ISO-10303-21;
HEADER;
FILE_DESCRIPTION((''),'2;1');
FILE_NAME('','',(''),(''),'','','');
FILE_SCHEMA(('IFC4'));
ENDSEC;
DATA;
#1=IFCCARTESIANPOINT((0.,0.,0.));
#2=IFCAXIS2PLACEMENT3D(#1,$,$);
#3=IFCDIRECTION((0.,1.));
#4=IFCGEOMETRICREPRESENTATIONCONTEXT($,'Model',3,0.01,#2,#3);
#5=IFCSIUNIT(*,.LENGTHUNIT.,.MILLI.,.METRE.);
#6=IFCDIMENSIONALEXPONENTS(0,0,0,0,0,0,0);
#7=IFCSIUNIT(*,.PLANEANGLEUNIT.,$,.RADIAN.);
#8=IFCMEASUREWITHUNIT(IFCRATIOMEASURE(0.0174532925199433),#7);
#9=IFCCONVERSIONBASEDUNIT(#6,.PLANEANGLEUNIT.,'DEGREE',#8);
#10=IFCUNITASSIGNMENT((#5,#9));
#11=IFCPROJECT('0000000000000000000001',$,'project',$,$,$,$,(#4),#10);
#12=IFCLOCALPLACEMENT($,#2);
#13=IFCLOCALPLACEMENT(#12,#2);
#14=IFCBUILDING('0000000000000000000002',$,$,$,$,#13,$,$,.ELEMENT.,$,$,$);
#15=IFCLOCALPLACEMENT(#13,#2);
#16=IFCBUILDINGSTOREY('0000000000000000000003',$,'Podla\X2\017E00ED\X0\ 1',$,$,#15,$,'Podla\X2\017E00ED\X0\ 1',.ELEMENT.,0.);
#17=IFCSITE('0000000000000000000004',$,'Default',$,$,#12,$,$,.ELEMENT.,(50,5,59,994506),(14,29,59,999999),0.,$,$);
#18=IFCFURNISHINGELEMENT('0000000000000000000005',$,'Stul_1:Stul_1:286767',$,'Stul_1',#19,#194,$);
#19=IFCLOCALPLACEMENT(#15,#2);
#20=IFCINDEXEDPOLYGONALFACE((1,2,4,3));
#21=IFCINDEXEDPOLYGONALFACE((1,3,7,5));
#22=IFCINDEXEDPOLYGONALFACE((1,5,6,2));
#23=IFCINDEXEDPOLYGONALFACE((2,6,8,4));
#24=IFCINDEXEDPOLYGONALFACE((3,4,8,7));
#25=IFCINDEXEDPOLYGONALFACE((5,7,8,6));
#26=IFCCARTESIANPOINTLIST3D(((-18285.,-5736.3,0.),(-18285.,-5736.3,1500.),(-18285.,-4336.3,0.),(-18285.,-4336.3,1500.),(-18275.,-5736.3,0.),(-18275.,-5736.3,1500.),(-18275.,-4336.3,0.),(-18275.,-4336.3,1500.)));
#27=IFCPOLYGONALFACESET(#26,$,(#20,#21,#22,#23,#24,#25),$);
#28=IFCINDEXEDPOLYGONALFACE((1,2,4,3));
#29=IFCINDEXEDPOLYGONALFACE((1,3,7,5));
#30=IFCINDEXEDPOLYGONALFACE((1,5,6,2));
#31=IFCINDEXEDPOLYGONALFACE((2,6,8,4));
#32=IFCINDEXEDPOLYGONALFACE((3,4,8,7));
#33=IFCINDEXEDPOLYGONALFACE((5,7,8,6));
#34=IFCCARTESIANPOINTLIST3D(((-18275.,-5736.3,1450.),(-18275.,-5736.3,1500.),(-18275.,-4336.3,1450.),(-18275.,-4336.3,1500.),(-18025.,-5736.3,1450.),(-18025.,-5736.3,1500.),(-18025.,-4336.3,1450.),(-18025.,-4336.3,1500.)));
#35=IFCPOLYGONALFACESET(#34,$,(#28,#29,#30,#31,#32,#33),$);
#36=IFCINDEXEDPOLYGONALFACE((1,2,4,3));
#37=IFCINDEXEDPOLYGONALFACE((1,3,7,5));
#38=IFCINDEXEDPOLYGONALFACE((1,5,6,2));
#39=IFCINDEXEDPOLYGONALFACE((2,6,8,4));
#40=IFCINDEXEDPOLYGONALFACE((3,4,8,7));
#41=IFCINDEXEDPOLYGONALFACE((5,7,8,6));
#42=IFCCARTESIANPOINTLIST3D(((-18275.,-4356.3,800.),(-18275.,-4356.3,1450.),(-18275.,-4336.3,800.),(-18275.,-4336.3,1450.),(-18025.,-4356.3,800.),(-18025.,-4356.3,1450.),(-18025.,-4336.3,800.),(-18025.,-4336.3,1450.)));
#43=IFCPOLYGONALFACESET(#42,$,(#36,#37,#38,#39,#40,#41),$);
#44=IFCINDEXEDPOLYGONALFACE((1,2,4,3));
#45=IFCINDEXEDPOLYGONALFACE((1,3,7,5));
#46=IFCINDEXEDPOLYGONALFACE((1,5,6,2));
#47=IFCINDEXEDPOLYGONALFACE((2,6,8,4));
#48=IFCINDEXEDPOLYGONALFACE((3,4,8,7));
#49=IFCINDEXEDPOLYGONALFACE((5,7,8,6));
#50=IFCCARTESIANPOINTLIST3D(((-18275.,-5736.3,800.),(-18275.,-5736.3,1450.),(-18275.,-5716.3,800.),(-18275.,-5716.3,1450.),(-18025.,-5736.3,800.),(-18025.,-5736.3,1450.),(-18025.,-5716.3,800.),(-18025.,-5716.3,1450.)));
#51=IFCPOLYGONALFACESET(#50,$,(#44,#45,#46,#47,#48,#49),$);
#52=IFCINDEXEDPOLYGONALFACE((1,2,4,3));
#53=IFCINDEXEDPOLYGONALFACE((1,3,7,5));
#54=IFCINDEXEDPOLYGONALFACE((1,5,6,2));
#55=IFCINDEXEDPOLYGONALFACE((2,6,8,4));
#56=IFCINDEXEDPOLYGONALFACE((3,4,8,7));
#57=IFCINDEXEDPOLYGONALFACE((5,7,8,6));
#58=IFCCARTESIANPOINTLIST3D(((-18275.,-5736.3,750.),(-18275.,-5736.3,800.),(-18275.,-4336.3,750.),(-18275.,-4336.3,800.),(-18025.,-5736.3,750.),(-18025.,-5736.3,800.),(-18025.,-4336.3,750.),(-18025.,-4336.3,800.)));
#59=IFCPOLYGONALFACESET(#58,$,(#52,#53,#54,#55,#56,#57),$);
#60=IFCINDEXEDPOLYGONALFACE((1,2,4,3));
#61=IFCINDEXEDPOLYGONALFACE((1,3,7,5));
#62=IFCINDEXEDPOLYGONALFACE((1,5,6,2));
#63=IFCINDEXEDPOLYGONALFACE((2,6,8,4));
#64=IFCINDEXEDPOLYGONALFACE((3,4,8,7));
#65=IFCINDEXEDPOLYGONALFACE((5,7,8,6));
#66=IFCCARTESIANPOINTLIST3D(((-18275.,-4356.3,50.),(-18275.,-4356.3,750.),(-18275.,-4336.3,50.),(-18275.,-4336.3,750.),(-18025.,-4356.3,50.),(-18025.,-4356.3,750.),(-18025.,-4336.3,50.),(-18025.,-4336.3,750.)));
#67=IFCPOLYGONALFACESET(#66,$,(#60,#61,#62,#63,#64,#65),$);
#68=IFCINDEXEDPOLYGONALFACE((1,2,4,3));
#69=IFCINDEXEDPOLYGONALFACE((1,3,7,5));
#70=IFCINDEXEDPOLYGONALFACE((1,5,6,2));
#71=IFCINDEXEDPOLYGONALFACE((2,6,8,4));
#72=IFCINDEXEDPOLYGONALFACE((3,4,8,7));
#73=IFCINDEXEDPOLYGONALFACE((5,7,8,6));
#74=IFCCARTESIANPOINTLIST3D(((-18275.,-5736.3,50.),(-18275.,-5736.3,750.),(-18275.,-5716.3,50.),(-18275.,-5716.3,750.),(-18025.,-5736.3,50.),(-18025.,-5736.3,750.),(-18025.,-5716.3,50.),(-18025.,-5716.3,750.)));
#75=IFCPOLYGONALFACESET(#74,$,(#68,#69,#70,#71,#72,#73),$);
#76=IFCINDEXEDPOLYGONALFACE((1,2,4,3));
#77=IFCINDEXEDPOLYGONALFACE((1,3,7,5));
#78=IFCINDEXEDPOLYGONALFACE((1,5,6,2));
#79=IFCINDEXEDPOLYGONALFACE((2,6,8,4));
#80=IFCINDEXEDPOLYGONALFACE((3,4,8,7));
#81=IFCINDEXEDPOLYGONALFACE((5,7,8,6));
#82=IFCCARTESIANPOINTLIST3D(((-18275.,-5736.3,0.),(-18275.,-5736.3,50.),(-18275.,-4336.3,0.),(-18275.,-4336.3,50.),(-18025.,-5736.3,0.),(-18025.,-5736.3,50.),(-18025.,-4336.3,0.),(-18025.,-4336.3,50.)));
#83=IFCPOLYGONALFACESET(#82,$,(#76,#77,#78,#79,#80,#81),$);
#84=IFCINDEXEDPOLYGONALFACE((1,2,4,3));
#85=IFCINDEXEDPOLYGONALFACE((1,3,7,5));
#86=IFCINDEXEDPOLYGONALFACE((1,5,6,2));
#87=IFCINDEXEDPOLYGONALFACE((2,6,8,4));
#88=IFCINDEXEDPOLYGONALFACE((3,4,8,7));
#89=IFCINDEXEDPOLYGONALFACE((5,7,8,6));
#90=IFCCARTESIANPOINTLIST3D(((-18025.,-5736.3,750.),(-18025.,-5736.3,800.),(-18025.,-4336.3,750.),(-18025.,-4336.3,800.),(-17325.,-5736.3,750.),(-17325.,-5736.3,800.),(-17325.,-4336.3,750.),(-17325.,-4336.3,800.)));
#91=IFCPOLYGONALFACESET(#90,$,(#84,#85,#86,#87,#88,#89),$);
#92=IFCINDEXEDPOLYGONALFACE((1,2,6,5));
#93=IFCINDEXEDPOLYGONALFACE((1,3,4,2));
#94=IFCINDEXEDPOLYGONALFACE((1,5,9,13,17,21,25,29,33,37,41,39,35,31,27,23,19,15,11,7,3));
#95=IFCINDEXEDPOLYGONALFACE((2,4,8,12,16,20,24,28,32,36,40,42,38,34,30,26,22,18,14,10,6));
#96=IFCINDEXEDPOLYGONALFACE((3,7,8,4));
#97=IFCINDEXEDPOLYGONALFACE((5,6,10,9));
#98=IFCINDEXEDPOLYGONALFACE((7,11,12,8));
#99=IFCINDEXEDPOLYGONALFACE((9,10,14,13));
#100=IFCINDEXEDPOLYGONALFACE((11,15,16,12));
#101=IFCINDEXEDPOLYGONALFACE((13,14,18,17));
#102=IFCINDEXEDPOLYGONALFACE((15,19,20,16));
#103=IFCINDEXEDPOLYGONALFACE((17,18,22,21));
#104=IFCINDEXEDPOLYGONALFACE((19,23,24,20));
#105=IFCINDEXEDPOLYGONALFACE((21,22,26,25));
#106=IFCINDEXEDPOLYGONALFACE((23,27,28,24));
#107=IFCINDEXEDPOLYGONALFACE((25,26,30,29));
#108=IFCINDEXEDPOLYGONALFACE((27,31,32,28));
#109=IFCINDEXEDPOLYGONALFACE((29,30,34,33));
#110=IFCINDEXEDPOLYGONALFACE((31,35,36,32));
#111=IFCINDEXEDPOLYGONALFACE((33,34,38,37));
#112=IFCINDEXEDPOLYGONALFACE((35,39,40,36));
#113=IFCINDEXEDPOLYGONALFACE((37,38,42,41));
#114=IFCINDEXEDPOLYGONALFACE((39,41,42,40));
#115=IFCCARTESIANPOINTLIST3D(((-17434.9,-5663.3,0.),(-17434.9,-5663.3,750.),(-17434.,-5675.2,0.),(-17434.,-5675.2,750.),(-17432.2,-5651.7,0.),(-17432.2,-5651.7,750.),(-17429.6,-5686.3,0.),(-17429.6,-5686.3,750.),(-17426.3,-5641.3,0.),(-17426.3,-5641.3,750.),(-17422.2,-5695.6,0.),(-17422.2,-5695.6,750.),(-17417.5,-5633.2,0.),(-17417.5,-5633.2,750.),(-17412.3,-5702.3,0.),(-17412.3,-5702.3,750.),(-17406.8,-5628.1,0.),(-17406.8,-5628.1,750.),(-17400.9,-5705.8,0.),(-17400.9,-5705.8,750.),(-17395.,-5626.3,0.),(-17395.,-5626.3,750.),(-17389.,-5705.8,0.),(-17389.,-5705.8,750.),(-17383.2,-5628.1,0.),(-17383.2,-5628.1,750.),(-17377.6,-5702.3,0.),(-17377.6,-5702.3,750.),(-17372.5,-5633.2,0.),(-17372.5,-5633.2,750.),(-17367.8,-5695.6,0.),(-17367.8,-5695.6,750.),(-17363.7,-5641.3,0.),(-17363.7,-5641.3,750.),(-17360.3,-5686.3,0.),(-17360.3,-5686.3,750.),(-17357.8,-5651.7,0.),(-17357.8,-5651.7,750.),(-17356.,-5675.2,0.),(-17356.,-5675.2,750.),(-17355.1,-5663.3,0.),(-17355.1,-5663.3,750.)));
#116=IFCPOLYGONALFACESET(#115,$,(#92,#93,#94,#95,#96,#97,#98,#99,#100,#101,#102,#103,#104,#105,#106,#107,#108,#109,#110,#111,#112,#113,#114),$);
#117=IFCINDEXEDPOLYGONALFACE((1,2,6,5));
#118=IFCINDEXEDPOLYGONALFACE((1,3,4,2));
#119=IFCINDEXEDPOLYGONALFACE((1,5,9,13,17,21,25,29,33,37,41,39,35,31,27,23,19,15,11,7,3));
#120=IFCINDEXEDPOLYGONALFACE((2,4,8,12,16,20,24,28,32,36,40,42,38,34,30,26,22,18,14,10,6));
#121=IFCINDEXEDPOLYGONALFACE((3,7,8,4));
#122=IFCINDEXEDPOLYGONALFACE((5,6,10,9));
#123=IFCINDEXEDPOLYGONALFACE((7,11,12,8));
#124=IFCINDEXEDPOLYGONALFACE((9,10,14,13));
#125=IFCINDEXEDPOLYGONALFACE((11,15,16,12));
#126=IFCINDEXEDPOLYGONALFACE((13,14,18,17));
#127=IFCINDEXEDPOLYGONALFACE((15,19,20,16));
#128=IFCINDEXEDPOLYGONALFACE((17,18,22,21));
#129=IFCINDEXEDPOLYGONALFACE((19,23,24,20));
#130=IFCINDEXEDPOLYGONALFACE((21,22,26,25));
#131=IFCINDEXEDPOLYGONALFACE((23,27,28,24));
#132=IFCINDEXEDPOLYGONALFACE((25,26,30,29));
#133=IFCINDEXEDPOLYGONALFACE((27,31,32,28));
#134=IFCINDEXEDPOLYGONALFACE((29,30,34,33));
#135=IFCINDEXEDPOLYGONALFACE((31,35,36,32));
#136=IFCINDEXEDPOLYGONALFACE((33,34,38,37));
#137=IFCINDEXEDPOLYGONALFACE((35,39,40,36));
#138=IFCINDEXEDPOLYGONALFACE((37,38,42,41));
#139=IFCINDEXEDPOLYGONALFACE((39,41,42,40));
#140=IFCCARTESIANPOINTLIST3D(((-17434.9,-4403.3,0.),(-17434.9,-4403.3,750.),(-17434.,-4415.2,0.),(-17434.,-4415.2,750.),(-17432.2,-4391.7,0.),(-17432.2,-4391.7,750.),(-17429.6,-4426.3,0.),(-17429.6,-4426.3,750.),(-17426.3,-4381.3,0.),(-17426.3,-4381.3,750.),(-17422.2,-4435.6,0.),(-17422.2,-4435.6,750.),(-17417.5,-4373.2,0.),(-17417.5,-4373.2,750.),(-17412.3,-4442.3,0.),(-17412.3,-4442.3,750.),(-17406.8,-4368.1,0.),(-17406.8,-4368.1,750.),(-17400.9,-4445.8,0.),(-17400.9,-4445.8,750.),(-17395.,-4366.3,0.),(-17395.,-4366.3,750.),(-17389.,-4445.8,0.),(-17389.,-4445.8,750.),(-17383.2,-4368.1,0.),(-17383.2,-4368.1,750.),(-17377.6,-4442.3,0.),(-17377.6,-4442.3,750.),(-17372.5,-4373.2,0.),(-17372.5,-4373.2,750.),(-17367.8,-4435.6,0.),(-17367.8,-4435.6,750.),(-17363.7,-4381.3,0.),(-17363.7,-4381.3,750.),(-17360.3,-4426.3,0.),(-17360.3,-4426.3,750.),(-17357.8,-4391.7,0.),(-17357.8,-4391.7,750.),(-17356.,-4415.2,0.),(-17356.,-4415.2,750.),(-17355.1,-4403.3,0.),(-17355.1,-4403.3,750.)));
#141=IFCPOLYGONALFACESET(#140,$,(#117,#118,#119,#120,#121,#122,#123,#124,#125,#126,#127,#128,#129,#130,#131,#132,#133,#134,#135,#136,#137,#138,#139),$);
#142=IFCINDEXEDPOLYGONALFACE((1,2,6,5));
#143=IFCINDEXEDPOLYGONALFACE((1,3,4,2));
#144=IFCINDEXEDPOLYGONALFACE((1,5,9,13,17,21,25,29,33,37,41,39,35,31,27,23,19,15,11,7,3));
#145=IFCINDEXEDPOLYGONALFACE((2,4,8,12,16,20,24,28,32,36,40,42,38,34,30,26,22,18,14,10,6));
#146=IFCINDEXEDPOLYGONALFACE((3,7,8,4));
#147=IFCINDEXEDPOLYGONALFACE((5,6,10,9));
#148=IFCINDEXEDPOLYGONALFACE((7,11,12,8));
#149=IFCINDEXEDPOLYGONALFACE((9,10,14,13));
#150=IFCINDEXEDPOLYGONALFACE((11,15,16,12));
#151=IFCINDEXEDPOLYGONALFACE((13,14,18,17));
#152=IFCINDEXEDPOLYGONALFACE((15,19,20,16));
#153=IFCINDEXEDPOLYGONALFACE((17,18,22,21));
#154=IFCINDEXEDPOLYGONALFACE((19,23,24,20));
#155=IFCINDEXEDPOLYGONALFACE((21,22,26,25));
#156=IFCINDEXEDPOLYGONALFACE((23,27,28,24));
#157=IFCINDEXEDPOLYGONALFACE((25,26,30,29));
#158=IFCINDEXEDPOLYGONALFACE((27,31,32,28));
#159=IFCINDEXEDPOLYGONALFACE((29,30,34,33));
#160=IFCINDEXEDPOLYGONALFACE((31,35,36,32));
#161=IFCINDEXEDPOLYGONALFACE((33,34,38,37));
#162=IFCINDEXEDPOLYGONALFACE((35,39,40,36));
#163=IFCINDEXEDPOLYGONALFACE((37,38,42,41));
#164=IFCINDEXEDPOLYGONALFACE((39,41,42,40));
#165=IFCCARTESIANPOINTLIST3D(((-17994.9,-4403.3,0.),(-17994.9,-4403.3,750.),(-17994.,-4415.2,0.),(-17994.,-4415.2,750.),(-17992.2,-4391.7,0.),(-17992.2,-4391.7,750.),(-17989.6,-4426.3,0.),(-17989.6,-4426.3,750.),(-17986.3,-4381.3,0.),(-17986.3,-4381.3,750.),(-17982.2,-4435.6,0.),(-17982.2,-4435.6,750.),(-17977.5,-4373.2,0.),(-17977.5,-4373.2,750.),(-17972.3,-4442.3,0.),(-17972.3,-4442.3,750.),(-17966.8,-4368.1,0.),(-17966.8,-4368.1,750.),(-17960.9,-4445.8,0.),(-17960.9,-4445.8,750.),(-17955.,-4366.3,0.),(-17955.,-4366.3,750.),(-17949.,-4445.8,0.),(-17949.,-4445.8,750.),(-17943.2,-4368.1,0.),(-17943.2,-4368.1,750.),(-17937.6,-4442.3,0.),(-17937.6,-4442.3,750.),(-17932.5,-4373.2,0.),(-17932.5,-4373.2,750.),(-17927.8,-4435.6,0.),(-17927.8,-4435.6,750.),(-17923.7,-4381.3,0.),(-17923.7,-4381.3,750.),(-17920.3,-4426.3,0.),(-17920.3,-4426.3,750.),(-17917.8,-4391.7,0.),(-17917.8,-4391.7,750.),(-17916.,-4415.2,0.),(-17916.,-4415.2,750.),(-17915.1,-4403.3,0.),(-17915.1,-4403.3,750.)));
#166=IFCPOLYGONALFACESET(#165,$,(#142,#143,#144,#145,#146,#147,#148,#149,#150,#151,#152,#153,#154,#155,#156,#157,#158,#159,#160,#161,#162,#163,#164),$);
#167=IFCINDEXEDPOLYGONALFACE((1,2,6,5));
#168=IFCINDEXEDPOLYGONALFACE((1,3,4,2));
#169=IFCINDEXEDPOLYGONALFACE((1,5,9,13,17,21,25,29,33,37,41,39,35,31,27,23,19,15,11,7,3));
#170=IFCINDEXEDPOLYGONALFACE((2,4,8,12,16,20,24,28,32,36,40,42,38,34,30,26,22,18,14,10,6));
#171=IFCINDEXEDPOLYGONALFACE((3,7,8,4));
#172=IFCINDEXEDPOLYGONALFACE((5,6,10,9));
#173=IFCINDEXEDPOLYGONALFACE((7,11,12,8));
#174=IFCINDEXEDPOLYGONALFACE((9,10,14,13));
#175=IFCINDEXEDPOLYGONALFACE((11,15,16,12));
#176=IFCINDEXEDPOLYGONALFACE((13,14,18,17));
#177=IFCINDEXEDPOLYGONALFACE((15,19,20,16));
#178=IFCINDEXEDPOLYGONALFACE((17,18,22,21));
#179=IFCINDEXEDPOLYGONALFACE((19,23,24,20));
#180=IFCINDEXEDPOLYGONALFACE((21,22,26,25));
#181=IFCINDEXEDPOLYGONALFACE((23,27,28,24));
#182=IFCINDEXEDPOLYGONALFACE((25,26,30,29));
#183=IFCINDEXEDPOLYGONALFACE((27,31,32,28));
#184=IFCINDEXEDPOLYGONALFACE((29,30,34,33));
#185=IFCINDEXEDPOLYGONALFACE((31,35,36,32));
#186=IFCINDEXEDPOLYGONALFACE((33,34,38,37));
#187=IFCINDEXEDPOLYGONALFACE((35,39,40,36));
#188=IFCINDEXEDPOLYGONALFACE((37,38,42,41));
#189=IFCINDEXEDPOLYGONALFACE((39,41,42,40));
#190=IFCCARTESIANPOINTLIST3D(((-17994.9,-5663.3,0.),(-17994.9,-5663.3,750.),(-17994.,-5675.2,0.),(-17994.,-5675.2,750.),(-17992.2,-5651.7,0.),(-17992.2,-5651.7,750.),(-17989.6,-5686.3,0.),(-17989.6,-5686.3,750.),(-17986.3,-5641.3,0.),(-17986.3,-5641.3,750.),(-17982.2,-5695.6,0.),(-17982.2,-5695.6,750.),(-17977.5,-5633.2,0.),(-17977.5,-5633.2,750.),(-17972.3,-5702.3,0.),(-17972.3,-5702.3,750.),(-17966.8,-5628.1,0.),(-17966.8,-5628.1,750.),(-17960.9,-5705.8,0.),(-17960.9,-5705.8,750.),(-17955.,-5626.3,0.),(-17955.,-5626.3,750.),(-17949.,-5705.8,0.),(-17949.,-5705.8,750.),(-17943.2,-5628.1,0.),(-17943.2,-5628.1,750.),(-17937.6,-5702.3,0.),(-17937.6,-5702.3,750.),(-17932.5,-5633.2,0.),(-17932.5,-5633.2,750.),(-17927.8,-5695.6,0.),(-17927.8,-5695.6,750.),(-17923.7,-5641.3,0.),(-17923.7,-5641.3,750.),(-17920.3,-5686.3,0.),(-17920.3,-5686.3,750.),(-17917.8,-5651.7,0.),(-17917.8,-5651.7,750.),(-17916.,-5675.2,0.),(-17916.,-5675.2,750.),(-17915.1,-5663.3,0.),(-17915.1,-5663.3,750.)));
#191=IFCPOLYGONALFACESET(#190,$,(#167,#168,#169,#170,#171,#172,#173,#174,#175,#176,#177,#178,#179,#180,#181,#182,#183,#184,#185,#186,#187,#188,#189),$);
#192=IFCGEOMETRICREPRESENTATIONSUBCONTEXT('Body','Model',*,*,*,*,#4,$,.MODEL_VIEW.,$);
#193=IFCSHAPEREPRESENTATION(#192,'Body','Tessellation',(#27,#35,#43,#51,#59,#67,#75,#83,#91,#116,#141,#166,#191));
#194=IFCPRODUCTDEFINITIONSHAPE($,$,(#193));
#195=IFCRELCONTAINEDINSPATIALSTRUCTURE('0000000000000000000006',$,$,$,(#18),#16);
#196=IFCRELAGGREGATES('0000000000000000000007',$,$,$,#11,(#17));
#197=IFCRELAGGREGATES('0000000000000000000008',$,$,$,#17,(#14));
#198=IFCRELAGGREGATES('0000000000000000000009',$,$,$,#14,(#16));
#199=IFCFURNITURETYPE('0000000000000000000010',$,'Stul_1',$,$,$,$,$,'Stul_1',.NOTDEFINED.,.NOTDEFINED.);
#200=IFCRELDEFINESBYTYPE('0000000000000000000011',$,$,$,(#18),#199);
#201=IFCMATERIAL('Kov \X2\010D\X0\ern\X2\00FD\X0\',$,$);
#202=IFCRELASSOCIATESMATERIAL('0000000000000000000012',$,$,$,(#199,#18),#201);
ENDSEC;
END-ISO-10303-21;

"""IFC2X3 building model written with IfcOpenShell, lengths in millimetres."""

from ifc_helpers import new_model, entity, si_unit, converted_unit, direction, frame, frame_2d, origin, origin_2d_with_axis, place, context, subcontext, project, spatial, rectangle, circle, extrude, source, transform, mapped, material, type_object, type_shapes, element, save


model = new_model("IFC2X3")

# Units and contexts
model_context = context("Model", 3, precision=0.01, world=origin(), true_north=direction((0.0, 1.0)))
body_context = subcontext(model_context, "Body", "Model", "MODEL_VIEW")
ifc_project = project(units=[si_unit("LENGTHUNIT", "METRE", prefix="MILLI"), converted_unit("PLANEANGLEUNIT", "DEGREE", entity("IfcRatioMeasure", 0.0174532925199433), si_unit("PLANEANGLEUNIT", "RADIAN"), dimensions=[0, 0, 0, 0, 0, 0, 0])], contexts=[model_context])

# Site, building, storey
site_placement = place(None, origin())
site = spatial("IfcSite", under=ifc_project, at=site_placement, Name="Default", CompositionType="ELEMENT", RefLatitude=(50, 5, 59, 994506), RefLongitude=(14, 29, 59, 999999), RefElevation=0.0)
building_placement = place(site_placement, origin())
building = spatial("IfcBuilding", under=site, at=building_placement, CompositionType="ELEMENT")
storey_placement = place(building_placement, origin())
storey = spatial("IfcBuildingStorey", under=building, at=storey_placement, Name="Podlaží 1", LongName="Podlaží 1", CompositionType="ELEMENT", Elevation=0.0)

# Furnishing element
ifc_material_1 = material(Name="Kov černý")
furniture_type = type_object("IfcFurnitureType", Name="Stul_1", ElementType="Stul_1", material=ifc_material_1)
shared_shape_1 = source(origin(), body_context, "Body", "SweptSolid", [
    extrude(rectangle(XDim=1400.0, YDim=10.0, at=origin_2d_with_axis()), frame((0.0, 605.0, 0.0), z_axis=(0.0, 0.0, 1.0), x_axis=(-1.0, 0.0, 0.0)), (0.0, 0.0, 1.0), 1500.0),
    extrude(rectangle(XDim=1400.0, YDim=250.0, at=frame_2d((0.0, 0.0), x_axis=(1.0, 0.0))), frame((0.0, 475.0, 1450.0), z_axis=(0.0, 0.0, 1.0), x_axis=(-1.0, 0.0, 0.0)), (0.0, 0.0, 1.0), 50.0),
    extrude(rectangle(XDim=20.0, YDim=250.0, at=origin_2d_with_axis()), frame((690.0, 475.0, 800.0), z_axis=(0.0, 0.0, 1.0), x_axis=(-1.0, 0.0, 0.0)), (0.0, 0.0, 1.0), 650.0),
    extrude(rectangle(XDim=20.0, YDim=250.0, at=frame_2d((0.0, 0.0), x_axis=(1.0, 0.0))), frame((-690.0, 475.0, 800.0), z_axis=(0.0, 0.0, 1.0), x_axis=(-1.0, 0.0, 0.0)), (0.0, 0.0, 1.0), 650.0),
    extrude(rectangle(XDim=1400.0, YDim=250.0, at=origin_2d_with_axis()), frame((0.0, 475.0, 750.0), z_axis=(0.0, 0.0, 1.0), x_axis=(-1.0, 0.0, 0.0)), (0.0, 0.0, 1.0), 50.0),
    extrude(rectangle(XDim=20.0, YDim=250.0, at=origin_2d_with_axis()), frame((690.0, 475.0, 50.0), z_axis=(0.0, 0.0, 1.0), x_axis=(-1.0, 0.0, 0.0)), (0.0, 0.0, 1.0), 700.0),
    extrude(rectangle(XDim=20.0, YDim=250.0, at=frame_2d((0.0, 0.0), x_axis=(1.0, 0.0))), frame((-690.0, 475.0, 50.0), z_axis=(0.0, 0.0, 1.0), x_axis=(-1.0, 0.0, 0.0)), (0.0, 0.0, 1.0), 700.0),
    extrude(rectangle(XDim=1400.0, YDim=250.0, at=origin_2d_with_axis()), frame((0.0, 475.0, 0.0), z_axis=(0.0, 0.0, 1.0), x_axis=(-1.0, 0.0, 0.0)), (0.0, 0.0, 1.0), 50.0),
    extrude(rectangle(XDim=1400.0, YDim=700.0, at=origin_2d_with_axis()), frame((0.0, 0.0, 750.0), z_axis=(0.0, 0.0, 1.0), x_axis=(-1.0, 0.0, 0.0)), (0.0, 0.0, 1.0), 50.0),
    extrude(circle(Radius=40.0, at=frame_2d((0.0, 0.0), x_axis=(1.0, 0.0))), frame((-630.0, -280.0, 0.0)), (0.0, 0.0, 1.0), 750.0),
    extrude(circle(Radius=40.0, at=frame_2d((0.0, 0.0), x_axis=(1.0, 0.0))), frame((630.0, -280.0, 0.0)), (0.0, 0.0, 1.0), 750.0),
    extrude(circle(Radius=40.0, at=frame_2d((0.0, 0.0), x_axis=(1.0, 0.0))), frame((630.0, 280.0, 0.0)), (0.0, 0.0, 1.0), 750.0),
    extrude(circle(Radius=40.0, at=frame_2d((0.0, 0.0), x_axis=(1.0, 0.0))), frame((-630.0, 280.0, 0.0)), (0.0, 0.0, 1.0), 750.0),
])
type_shapes(furniture_type, [shared_shape_1])
for number, where, z_axis, x_axis, name in (
    (1, (-17675.0, -5036.3, 0.0), (0.0, 0.0, 1.0), (0.0, 1.0, 0.0), "Stul_1:Stul_1:286767"),
):
    element("IfcFurnishingElement", number, at=place(storey_placement, frame(where, z_axis=z_axis, x_axis=x_axis)), inside=storey, type_object=furniture_type, material=ifc_material_1, Name=name, ObjectType="Stul_1", context=body_context, shape_type="MappedRepresentation", body=[
        mapped(shared_shape_1, transform((0.0, 0.0, 0.0), scale=1.0)),
    ])

save(model, "model.ifc")
